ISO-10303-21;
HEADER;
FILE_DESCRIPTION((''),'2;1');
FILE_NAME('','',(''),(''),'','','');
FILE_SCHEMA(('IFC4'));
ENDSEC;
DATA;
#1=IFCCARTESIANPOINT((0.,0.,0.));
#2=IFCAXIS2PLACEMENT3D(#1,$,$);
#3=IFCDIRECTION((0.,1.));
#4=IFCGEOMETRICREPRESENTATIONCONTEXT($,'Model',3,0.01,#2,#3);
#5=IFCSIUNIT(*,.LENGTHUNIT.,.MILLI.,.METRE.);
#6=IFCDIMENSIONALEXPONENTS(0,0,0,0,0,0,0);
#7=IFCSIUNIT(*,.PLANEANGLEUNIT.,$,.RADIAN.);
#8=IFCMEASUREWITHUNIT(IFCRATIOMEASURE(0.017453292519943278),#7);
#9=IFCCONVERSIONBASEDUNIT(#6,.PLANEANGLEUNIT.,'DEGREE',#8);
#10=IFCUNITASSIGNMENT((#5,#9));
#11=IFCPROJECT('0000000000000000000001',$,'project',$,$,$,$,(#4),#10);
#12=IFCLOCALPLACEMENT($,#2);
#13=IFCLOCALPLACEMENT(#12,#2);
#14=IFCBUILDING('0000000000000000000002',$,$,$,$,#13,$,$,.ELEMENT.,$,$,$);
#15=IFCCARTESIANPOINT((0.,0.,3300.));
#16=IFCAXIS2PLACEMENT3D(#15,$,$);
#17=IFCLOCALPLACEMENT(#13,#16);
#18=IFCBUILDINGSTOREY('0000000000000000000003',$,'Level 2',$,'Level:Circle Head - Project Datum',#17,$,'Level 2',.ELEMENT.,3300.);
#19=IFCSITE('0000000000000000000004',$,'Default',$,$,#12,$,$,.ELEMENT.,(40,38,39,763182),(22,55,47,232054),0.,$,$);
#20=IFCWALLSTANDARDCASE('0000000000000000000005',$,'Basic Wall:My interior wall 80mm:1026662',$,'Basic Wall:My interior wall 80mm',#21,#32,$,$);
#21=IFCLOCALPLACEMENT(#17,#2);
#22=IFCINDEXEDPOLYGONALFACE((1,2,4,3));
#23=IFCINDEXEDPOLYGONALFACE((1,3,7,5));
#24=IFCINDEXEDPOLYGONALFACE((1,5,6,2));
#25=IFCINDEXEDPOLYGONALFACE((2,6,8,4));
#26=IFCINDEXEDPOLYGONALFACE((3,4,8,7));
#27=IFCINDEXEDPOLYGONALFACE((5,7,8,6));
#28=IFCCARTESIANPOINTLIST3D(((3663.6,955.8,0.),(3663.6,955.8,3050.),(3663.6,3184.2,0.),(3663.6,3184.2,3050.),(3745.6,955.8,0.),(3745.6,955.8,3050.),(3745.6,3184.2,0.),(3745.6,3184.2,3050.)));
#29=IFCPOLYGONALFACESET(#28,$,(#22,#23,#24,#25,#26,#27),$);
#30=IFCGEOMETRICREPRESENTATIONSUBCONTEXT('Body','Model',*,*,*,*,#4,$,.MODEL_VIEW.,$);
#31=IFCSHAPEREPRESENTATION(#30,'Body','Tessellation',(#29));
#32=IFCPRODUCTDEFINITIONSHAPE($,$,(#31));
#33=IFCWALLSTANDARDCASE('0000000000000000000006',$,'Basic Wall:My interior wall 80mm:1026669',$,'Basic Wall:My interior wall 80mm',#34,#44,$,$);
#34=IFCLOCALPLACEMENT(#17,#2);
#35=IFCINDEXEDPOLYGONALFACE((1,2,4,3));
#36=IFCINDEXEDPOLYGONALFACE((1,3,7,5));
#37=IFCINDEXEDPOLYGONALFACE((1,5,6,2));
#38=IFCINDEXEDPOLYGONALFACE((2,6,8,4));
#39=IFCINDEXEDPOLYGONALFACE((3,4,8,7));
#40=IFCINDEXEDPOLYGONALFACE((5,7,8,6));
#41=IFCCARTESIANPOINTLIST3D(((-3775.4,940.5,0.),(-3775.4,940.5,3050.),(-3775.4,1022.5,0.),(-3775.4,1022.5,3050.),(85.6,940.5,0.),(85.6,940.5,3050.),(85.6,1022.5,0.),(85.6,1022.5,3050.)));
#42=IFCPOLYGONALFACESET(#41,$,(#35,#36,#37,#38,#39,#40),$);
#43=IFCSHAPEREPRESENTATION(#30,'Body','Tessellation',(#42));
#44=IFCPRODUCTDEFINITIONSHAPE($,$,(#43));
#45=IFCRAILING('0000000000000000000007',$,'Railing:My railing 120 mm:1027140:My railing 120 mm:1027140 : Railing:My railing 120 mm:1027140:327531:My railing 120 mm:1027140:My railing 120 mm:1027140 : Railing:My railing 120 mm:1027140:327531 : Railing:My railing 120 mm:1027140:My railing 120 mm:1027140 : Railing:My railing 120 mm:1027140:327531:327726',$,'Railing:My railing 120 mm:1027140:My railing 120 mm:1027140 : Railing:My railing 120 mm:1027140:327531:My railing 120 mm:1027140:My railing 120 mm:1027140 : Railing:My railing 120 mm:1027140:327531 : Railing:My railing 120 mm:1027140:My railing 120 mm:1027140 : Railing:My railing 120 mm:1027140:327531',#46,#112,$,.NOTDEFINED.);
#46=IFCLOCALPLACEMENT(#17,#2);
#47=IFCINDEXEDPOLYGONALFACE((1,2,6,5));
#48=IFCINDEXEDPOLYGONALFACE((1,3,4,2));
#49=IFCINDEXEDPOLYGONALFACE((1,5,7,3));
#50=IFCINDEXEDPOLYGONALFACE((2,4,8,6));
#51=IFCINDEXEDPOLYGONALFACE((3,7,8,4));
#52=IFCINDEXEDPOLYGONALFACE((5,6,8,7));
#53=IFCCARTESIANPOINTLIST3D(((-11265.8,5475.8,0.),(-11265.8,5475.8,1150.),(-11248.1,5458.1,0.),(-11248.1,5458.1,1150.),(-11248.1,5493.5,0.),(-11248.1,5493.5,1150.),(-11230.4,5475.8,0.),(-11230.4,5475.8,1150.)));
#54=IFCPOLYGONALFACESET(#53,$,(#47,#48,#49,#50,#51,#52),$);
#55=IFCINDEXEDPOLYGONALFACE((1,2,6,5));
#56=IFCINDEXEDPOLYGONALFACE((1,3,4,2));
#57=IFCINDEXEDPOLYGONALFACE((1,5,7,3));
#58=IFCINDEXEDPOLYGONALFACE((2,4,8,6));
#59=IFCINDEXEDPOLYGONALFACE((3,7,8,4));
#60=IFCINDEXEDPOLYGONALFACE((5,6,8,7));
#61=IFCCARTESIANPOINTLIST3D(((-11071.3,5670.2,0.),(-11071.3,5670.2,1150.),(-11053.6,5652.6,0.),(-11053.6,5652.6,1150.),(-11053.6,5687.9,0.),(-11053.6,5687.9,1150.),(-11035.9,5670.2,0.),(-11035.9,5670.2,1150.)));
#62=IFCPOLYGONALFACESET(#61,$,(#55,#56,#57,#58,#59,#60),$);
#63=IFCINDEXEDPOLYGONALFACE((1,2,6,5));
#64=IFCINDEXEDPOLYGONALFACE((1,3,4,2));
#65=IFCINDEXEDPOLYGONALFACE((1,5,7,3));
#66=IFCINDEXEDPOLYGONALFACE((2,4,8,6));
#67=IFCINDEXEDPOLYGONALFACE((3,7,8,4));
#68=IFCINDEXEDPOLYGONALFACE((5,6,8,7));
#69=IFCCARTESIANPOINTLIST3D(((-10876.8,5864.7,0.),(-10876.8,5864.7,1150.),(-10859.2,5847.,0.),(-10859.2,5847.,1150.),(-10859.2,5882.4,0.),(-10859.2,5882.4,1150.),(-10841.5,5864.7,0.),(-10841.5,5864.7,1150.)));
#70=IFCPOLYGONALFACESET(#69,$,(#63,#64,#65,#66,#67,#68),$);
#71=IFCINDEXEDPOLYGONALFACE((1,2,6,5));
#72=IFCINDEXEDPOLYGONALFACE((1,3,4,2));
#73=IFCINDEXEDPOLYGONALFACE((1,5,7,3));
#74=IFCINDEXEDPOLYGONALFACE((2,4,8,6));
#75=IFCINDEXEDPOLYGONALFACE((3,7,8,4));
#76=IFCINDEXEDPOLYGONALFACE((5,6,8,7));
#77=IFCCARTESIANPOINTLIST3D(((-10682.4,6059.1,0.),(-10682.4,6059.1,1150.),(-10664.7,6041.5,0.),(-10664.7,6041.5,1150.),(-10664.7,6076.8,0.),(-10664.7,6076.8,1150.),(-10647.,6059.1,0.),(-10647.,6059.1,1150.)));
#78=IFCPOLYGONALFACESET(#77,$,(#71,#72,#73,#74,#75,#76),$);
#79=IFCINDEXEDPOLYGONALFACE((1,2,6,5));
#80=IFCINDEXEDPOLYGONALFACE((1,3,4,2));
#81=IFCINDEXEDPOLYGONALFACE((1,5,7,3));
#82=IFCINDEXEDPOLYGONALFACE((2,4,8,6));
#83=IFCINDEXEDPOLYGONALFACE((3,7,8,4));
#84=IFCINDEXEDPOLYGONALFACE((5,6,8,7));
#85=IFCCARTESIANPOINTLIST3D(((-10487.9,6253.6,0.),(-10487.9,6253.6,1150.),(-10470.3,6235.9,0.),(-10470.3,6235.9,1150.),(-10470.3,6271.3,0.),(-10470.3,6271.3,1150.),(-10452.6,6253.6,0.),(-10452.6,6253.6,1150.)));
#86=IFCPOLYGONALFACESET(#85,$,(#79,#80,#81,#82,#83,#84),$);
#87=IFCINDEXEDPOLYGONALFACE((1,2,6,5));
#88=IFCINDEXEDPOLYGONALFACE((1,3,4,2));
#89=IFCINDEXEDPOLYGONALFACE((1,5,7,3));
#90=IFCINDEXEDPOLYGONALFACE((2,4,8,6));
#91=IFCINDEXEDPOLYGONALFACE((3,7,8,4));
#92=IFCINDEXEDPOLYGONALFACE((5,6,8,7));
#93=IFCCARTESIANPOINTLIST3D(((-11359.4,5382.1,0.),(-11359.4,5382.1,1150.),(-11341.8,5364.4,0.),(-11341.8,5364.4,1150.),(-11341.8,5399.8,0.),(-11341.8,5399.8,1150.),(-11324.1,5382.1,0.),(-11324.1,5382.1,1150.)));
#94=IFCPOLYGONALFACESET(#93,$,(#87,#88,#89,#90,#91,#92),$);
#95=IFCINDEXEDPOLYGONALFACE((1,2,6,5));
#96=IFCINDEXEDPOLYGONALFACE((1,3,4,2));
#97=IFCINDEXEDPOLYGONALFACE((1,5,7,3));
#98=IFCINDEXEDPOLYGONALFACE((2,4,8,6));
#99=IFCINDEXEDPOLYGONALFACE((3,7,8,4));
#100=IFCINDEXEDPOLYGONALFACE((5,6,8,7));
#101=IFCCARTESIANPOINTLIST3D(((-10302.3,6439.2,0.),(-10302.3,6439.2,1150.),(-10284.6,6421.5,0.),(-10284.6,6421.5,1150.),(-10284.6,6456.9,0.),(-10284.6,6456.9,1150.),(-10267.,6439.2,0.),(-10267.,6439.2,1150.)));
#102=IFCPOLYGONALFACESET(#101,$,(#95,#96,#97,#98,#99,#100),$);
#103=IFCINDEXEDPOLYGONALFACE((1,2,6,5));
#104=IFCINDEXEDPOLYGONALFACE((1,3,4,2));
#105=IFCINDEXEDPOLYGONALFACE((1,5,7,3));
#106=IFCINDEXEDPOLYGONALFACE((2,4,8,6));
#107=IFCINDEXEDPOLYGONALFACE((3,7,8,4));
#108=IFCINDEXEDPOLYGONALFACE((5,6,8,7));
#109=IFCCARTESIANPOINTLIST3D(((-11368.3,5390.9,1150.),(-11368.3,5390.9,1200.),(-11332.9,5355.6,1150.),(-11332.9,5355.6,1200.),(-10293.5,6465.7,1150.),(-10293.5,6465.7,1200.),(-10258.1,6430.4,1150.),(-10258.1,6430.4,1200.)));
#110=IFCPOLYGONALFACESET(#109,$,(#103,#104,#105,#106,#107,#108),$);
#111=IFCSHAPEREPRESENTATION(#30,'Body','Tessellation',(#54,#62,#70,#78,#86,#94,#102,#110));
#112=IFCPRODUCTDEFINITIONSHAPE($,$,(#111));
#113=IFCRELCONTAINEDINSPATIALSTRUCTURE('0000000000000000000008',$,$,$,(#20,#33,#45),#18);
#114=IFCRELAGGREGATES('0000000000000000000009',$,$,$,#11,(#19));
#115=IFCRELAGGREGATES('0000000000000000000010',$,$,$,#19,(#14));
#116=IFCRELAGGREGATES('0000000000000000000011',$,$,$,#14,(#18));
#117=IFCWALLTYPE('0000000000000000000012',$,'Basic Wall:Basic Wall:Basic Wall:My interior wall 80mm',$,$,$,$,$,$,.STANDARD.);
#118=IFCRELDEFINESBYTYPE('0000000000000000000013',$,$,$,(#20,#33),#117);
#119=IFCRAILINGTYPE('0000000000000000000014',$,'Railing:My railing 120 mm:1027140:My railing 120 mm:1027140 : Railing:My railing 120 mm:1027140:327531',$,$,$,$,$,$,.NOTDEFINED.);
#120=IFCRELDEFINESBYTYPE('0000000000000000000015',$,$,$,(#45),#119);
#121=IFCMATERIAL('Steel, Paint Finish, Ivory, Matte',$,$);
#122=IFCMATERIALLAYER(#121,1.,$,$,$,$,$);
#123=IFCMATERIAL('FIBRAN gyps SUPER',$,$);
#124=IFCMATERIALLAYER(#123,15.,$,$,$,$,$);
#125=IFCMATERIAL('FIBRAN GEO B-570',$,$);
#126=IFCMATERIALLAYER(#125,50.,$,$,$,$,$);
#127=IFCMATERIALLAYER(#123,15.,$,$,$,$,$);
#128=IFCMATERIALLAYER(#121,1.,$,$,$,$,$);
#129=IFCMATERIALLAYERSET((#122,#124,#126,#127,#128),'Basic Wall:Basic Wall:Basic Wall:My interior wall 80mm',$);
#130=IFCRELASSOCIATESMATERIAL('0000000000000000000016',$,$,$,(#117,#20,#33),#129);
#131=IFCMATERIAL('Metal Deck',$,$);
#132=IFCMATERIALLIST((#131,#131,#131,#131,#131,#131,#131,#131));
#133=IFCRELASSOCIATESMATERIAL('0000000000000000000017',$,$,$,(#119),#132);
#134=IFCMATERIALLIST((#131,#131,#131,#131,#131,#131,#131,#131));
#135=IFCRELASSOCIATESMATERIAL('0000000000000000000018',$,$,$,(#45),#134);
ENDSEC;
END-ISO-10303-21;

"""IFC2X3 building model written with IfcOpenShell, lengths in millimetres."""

from ifc_helpers import new_model, entity, si_unit, converted_unit, direction, frame, frame_2d, origin, origin_2d_with_axis, place, context, subcontext, project, spatial, rectangle, extrude, source, transform, mapped, material, material_list, layer, layer_set, layer_usage, type_object, type_shapes, element, save


model = new_model("IFC2X3")

# Units and contexts
model_context = context("Model", 3, precision=0.01, world=origin(), true_north=direction((0.0, 1.0)))
body_context = subcontext(model_context, "Body", "Model", "MODEL_VIEW")
ifc_project = project(units=[si_unit("LENGTHUNIT", "METRE", prefix="MILLI"), converted_unit("PLANEANGLEUNIT", "DEGREE", entity("IfcRatioMeasure", 0.017453292519943278), si_unit("PLANEANGLEUNIT", "RADIAN"), dimensions=[0, 0, 0, 0, 0, 0, 0])], contexts=[model_context])

# Site, building, storey
site_placement = place(None, origin())
site = spatial("IfcSite", under=ifc_project, at=site_placement, Name="Default", CompositionType="ELEMENT", RefLatitude=(40, 38, 39, 763182), RefLongitude=(22, 55, 47, 232054), RefElevation=0.0)
building_placement = place(site_placement, origin())
building = spatial("IfcBuilding", under=site, at=building_placement, CompositionType="ELEMENT")
storey_placement = place(building_placement, frame((0.0, 0.0, 3300.0)))
storey = spatial("IfcBuildingStorey", under=building, at=storey_placement, Name="Level 2", ObjectType="Level:Circle Head - Project Datum", LongName="Level 2", CompositionType="ELEMENT", Elevation=3300.0)

# Shared definitions
ifc_material_1 = material(Name="FIBRAN gyps SUPER")

# Shared definitions
ifc_material_2 = material(Name="FIBRAN GEO B-570")

# Shared definitions
ifc_material_3 = material(Name="Steel, Paint Finish, Ivory, Matte")
ifc_layer_1 = layer(ifc_material_3, 1.0)
ifc_layer_2 = layer(ifc_material_1, 15.0)
ifc_layer_3 = layer(ifc_material_2, 50.0)
ifc_layer_4 = layer(ifc_material_1, 15.0)
ifc_layer_5 = layer(ifc_material_3, 1.0)
ifc_layer_set_1 = layer_set([ifc_layer_1, ifc_layer_2, ifc_layer_3, ifc_layer_4, ifc_layer_5], Name="Basic Wall:Basic Wall:Basic Wall:My interior wall 80mm")
wall_type_1 = type_object("IfcWallType", Name="Basic Wall:Basic Wall:Basic Wall:My interior wall 80mm", PredefinedType="STANDARD", material=ifc_layer_set_1)

# Walls
ifc_layer_usage_1 = layer_usage(ifc_layer_set_1, "AXIS2", "NEGATIVE", 41.0)
wall_1_placement = place(storey_placement, frame((3704.6, 3184.2, 0.0), z_axis=(0.0, 0.0, 1.0), x_axis=(0.0, -1.0, 0.0)))
element("IfcWallStandardCase", 1, at=wall_1_placement, inside=storey, type_object=wall_type_1, material=ifc_layer_usage_1, Name="Basic Wall:My interior wall 80mm:1026662", ObjectType="Basic Wall:My interior wall 80mm", context=body_context, shape_type="SweptSolid", body=[
    extrude(rectangle(XDim=2228.4, YDim=82.0, at=frame_2d((1114.2, 0.0), x_axis=(-1.0, 0.0))), origin(), (0.0, 0.0, 1.0), 3050.0),
])
ifc_layer_usage_2 = layer_usage(ifc_layer_set_1, "AXIS2", "NEGATIVE", 41.0)
wall_2_placement = place(storey_placement, frame((85.6, 981.5, 0.0), z_axis=(0.0, 0.0, 1.0), x_axis=(-1.0, 0.0, 0.0)))
element("IfcWallStandardCase", 2, at=wall_2_placement, inside=storey, type_object=wall_type_1, material=ifc_layer_usage_2, Name="Basic Wall:My interior wall 80mm:1026669", ObjectType="Basic Wall:My interior wall 80mm", context=body_context, shape_type="SweptSolid", body=[
    extrude(rectangle(XDim=3861.0, YDim=82.0, at=frame_2d((1930.5, 0.0), x_axis=(-1.0, 0.0))), origin(), (0.0, 0.0, 1.0), 3050.0),
])

# Railing
ifc_material_4 = material(Name="Metal Deck")
ifc_material_list_1 = material_list([ifc_material_4, ifc_material_4, ifc_material_4, ifc_material_4, ifc_material_4, ifc_material_4, ifc_material_4, ifc_material_4])
ifc_material_list_2 = material_list([ifc_material_4, ifc_material_4, ifc_material_4, ifc_material_4, ifc_material_4, ifc_material_4, ifc_material_4, ifc_material_4])
railing_type_1 = type_object("IfcRailingType", Name="Railing:My railing 120 mm:1027140:My railing 120 mm:1027140 : Railing:My railing 120 mm:1027140:327531", PredefinedType="NOTDEFINED", material=ifc_material_list_2)
shared_shape_1 = source(origin(), body_context, "Body", "SweptSolid", [
    extrude(rectangle(XDim=25.0, YDim=25.0, at=frame_2d((0.0, 0.0), x_axis=(1.0, 0.0))), frame((-11248.1, 5475.8, 3300.0), z_axis=(0.0, 0.0, 1.0), x_axis=(0.707107, 0.707107, 0.0)), (0.0, 0.0, 1.0), 1150.0),
    extrude(rectangle(XDim=25.0, YDim=25.0, at=origin_2d_with_axis()), frame((-11053.6, 5670.2, 3300.0), z_axis=(0.0, 0.0, 1.0), x_axis=(0.707107, 0.707107, 0.0)), (0.0, 0.0, 1.0), 1150.0),
    extrude(rectangle(XDim=25.0, YDim=25.0, at=frame_2d((0.0, 0.0), x_axis=(1.0, 0.0))), frame((-10859.2, 5864.7, 3300.0), z_axis=(0.0, 0.0, 1.0), x_axis=(0.707107, 0.707107, 0.0)), (0.0, 0.0, 1.0), 1150.0),
    extrude(rectangle(XDim=25.0, YDim=25.0, at=origin_2d_with_axis()), frame((-10664.7, 6059.1, 3300.0), z_axis=(0.0, 0.0, 1.0), x_axis=(0.707107, 0.707107, 0.0)), (0.0, 0.0, 1.0), 1150.0),
    extrude(rectangle(XDim=25.0, YDim=25.0, at=origin_2d_with_axis()), frame((-10470.3, 6253.6, 3300.0), z_axis=(0.0, 0.0, 1.0), x_axis=(0.707107, 0.707107, 0.0)), (0.0, 0.0, 1.0), 1150.0),
    extrude(rectangle(XDim=25.0, YDim=25.0, at=frame_2d((0.0, 0.0), x_axis=(1.0, 0.0))), frame((-11341.8, 5382.1, 3300.0), z_axis=(0.0, 0.0, 1.0), x_axis=(0.707107, 0.707107, 0.0)), (0.0, 0.0, 1.0), 1150.0),
    extrude(rectangle(XDim=25.0, YDim=25.0, at=frame_2d((0.0, 0.0), x_axis=(1.0, 0.0))), frame((-10284.6, 6439.2, 3300.0), z_axis=(0.0, 0.0, 1.0), x_axis=(0.707107, 0.707107, 0.0)), (0.0, 0.0, 1.0), 1150.0),
    extrude(rectangle(XDim=1520.0, YDim=50.0, at=frame_2d((0.0, 0.0), x_axis=(1.0, 0.0))), frame((-10813.2, 5910.6, 4450.0), z_axis=(0.0, 0.0, 1.0), x_axis=(0.707107, 0.707107, 0.0)), (0.0, 0.0, 1.0), 50.0),
])
type_shapes(railing_type_1, [shared_shape_1])
railing_1_placement = place(storey_placement, frame((0.0, 0.0, -3300.0)))
element("IfcRailing", 3, at=railing_1_placement, inside=storey, type_object=railing_type_1, material=ifc_material_list_1, Name="Railing:My railing 120 mm:1027140:My railing 120 mm:1027140 : Railing:My railing 120 mm:1027140:327531:My railing 120 mm:1027140:My railing 120 mm:1027140 : Railing:My railing 120 mm:1027140:327531 : Railing:My railing 120 mm:1027140:My railing 120 mm:1027140 : Railing:My railing 120 mm:1027140:327531:327726", ObjectType="Railing:My railing 120 mm:1027140:My railing 120 mm:1027140 : Railing:My railing 120 mm:1027140:327531:My railing 120 mm:1027140:My railing 120 mm:1027140 : Railing:My railing 120 mm:1027140:327531 : Railing:My railing 120 mm:1027140:My railing 120 mm:1027140 : Railing:My railing 120 mm:1027140:327531", PredefinedType="NOTDEFINED", context=body_context, shape_type="MappedRepresentation", body=[
    mapped(shared_shape_1, transform((0.0, 0.0, 0.0), scale=1.0)),
])

save(model, "model.ifc")
